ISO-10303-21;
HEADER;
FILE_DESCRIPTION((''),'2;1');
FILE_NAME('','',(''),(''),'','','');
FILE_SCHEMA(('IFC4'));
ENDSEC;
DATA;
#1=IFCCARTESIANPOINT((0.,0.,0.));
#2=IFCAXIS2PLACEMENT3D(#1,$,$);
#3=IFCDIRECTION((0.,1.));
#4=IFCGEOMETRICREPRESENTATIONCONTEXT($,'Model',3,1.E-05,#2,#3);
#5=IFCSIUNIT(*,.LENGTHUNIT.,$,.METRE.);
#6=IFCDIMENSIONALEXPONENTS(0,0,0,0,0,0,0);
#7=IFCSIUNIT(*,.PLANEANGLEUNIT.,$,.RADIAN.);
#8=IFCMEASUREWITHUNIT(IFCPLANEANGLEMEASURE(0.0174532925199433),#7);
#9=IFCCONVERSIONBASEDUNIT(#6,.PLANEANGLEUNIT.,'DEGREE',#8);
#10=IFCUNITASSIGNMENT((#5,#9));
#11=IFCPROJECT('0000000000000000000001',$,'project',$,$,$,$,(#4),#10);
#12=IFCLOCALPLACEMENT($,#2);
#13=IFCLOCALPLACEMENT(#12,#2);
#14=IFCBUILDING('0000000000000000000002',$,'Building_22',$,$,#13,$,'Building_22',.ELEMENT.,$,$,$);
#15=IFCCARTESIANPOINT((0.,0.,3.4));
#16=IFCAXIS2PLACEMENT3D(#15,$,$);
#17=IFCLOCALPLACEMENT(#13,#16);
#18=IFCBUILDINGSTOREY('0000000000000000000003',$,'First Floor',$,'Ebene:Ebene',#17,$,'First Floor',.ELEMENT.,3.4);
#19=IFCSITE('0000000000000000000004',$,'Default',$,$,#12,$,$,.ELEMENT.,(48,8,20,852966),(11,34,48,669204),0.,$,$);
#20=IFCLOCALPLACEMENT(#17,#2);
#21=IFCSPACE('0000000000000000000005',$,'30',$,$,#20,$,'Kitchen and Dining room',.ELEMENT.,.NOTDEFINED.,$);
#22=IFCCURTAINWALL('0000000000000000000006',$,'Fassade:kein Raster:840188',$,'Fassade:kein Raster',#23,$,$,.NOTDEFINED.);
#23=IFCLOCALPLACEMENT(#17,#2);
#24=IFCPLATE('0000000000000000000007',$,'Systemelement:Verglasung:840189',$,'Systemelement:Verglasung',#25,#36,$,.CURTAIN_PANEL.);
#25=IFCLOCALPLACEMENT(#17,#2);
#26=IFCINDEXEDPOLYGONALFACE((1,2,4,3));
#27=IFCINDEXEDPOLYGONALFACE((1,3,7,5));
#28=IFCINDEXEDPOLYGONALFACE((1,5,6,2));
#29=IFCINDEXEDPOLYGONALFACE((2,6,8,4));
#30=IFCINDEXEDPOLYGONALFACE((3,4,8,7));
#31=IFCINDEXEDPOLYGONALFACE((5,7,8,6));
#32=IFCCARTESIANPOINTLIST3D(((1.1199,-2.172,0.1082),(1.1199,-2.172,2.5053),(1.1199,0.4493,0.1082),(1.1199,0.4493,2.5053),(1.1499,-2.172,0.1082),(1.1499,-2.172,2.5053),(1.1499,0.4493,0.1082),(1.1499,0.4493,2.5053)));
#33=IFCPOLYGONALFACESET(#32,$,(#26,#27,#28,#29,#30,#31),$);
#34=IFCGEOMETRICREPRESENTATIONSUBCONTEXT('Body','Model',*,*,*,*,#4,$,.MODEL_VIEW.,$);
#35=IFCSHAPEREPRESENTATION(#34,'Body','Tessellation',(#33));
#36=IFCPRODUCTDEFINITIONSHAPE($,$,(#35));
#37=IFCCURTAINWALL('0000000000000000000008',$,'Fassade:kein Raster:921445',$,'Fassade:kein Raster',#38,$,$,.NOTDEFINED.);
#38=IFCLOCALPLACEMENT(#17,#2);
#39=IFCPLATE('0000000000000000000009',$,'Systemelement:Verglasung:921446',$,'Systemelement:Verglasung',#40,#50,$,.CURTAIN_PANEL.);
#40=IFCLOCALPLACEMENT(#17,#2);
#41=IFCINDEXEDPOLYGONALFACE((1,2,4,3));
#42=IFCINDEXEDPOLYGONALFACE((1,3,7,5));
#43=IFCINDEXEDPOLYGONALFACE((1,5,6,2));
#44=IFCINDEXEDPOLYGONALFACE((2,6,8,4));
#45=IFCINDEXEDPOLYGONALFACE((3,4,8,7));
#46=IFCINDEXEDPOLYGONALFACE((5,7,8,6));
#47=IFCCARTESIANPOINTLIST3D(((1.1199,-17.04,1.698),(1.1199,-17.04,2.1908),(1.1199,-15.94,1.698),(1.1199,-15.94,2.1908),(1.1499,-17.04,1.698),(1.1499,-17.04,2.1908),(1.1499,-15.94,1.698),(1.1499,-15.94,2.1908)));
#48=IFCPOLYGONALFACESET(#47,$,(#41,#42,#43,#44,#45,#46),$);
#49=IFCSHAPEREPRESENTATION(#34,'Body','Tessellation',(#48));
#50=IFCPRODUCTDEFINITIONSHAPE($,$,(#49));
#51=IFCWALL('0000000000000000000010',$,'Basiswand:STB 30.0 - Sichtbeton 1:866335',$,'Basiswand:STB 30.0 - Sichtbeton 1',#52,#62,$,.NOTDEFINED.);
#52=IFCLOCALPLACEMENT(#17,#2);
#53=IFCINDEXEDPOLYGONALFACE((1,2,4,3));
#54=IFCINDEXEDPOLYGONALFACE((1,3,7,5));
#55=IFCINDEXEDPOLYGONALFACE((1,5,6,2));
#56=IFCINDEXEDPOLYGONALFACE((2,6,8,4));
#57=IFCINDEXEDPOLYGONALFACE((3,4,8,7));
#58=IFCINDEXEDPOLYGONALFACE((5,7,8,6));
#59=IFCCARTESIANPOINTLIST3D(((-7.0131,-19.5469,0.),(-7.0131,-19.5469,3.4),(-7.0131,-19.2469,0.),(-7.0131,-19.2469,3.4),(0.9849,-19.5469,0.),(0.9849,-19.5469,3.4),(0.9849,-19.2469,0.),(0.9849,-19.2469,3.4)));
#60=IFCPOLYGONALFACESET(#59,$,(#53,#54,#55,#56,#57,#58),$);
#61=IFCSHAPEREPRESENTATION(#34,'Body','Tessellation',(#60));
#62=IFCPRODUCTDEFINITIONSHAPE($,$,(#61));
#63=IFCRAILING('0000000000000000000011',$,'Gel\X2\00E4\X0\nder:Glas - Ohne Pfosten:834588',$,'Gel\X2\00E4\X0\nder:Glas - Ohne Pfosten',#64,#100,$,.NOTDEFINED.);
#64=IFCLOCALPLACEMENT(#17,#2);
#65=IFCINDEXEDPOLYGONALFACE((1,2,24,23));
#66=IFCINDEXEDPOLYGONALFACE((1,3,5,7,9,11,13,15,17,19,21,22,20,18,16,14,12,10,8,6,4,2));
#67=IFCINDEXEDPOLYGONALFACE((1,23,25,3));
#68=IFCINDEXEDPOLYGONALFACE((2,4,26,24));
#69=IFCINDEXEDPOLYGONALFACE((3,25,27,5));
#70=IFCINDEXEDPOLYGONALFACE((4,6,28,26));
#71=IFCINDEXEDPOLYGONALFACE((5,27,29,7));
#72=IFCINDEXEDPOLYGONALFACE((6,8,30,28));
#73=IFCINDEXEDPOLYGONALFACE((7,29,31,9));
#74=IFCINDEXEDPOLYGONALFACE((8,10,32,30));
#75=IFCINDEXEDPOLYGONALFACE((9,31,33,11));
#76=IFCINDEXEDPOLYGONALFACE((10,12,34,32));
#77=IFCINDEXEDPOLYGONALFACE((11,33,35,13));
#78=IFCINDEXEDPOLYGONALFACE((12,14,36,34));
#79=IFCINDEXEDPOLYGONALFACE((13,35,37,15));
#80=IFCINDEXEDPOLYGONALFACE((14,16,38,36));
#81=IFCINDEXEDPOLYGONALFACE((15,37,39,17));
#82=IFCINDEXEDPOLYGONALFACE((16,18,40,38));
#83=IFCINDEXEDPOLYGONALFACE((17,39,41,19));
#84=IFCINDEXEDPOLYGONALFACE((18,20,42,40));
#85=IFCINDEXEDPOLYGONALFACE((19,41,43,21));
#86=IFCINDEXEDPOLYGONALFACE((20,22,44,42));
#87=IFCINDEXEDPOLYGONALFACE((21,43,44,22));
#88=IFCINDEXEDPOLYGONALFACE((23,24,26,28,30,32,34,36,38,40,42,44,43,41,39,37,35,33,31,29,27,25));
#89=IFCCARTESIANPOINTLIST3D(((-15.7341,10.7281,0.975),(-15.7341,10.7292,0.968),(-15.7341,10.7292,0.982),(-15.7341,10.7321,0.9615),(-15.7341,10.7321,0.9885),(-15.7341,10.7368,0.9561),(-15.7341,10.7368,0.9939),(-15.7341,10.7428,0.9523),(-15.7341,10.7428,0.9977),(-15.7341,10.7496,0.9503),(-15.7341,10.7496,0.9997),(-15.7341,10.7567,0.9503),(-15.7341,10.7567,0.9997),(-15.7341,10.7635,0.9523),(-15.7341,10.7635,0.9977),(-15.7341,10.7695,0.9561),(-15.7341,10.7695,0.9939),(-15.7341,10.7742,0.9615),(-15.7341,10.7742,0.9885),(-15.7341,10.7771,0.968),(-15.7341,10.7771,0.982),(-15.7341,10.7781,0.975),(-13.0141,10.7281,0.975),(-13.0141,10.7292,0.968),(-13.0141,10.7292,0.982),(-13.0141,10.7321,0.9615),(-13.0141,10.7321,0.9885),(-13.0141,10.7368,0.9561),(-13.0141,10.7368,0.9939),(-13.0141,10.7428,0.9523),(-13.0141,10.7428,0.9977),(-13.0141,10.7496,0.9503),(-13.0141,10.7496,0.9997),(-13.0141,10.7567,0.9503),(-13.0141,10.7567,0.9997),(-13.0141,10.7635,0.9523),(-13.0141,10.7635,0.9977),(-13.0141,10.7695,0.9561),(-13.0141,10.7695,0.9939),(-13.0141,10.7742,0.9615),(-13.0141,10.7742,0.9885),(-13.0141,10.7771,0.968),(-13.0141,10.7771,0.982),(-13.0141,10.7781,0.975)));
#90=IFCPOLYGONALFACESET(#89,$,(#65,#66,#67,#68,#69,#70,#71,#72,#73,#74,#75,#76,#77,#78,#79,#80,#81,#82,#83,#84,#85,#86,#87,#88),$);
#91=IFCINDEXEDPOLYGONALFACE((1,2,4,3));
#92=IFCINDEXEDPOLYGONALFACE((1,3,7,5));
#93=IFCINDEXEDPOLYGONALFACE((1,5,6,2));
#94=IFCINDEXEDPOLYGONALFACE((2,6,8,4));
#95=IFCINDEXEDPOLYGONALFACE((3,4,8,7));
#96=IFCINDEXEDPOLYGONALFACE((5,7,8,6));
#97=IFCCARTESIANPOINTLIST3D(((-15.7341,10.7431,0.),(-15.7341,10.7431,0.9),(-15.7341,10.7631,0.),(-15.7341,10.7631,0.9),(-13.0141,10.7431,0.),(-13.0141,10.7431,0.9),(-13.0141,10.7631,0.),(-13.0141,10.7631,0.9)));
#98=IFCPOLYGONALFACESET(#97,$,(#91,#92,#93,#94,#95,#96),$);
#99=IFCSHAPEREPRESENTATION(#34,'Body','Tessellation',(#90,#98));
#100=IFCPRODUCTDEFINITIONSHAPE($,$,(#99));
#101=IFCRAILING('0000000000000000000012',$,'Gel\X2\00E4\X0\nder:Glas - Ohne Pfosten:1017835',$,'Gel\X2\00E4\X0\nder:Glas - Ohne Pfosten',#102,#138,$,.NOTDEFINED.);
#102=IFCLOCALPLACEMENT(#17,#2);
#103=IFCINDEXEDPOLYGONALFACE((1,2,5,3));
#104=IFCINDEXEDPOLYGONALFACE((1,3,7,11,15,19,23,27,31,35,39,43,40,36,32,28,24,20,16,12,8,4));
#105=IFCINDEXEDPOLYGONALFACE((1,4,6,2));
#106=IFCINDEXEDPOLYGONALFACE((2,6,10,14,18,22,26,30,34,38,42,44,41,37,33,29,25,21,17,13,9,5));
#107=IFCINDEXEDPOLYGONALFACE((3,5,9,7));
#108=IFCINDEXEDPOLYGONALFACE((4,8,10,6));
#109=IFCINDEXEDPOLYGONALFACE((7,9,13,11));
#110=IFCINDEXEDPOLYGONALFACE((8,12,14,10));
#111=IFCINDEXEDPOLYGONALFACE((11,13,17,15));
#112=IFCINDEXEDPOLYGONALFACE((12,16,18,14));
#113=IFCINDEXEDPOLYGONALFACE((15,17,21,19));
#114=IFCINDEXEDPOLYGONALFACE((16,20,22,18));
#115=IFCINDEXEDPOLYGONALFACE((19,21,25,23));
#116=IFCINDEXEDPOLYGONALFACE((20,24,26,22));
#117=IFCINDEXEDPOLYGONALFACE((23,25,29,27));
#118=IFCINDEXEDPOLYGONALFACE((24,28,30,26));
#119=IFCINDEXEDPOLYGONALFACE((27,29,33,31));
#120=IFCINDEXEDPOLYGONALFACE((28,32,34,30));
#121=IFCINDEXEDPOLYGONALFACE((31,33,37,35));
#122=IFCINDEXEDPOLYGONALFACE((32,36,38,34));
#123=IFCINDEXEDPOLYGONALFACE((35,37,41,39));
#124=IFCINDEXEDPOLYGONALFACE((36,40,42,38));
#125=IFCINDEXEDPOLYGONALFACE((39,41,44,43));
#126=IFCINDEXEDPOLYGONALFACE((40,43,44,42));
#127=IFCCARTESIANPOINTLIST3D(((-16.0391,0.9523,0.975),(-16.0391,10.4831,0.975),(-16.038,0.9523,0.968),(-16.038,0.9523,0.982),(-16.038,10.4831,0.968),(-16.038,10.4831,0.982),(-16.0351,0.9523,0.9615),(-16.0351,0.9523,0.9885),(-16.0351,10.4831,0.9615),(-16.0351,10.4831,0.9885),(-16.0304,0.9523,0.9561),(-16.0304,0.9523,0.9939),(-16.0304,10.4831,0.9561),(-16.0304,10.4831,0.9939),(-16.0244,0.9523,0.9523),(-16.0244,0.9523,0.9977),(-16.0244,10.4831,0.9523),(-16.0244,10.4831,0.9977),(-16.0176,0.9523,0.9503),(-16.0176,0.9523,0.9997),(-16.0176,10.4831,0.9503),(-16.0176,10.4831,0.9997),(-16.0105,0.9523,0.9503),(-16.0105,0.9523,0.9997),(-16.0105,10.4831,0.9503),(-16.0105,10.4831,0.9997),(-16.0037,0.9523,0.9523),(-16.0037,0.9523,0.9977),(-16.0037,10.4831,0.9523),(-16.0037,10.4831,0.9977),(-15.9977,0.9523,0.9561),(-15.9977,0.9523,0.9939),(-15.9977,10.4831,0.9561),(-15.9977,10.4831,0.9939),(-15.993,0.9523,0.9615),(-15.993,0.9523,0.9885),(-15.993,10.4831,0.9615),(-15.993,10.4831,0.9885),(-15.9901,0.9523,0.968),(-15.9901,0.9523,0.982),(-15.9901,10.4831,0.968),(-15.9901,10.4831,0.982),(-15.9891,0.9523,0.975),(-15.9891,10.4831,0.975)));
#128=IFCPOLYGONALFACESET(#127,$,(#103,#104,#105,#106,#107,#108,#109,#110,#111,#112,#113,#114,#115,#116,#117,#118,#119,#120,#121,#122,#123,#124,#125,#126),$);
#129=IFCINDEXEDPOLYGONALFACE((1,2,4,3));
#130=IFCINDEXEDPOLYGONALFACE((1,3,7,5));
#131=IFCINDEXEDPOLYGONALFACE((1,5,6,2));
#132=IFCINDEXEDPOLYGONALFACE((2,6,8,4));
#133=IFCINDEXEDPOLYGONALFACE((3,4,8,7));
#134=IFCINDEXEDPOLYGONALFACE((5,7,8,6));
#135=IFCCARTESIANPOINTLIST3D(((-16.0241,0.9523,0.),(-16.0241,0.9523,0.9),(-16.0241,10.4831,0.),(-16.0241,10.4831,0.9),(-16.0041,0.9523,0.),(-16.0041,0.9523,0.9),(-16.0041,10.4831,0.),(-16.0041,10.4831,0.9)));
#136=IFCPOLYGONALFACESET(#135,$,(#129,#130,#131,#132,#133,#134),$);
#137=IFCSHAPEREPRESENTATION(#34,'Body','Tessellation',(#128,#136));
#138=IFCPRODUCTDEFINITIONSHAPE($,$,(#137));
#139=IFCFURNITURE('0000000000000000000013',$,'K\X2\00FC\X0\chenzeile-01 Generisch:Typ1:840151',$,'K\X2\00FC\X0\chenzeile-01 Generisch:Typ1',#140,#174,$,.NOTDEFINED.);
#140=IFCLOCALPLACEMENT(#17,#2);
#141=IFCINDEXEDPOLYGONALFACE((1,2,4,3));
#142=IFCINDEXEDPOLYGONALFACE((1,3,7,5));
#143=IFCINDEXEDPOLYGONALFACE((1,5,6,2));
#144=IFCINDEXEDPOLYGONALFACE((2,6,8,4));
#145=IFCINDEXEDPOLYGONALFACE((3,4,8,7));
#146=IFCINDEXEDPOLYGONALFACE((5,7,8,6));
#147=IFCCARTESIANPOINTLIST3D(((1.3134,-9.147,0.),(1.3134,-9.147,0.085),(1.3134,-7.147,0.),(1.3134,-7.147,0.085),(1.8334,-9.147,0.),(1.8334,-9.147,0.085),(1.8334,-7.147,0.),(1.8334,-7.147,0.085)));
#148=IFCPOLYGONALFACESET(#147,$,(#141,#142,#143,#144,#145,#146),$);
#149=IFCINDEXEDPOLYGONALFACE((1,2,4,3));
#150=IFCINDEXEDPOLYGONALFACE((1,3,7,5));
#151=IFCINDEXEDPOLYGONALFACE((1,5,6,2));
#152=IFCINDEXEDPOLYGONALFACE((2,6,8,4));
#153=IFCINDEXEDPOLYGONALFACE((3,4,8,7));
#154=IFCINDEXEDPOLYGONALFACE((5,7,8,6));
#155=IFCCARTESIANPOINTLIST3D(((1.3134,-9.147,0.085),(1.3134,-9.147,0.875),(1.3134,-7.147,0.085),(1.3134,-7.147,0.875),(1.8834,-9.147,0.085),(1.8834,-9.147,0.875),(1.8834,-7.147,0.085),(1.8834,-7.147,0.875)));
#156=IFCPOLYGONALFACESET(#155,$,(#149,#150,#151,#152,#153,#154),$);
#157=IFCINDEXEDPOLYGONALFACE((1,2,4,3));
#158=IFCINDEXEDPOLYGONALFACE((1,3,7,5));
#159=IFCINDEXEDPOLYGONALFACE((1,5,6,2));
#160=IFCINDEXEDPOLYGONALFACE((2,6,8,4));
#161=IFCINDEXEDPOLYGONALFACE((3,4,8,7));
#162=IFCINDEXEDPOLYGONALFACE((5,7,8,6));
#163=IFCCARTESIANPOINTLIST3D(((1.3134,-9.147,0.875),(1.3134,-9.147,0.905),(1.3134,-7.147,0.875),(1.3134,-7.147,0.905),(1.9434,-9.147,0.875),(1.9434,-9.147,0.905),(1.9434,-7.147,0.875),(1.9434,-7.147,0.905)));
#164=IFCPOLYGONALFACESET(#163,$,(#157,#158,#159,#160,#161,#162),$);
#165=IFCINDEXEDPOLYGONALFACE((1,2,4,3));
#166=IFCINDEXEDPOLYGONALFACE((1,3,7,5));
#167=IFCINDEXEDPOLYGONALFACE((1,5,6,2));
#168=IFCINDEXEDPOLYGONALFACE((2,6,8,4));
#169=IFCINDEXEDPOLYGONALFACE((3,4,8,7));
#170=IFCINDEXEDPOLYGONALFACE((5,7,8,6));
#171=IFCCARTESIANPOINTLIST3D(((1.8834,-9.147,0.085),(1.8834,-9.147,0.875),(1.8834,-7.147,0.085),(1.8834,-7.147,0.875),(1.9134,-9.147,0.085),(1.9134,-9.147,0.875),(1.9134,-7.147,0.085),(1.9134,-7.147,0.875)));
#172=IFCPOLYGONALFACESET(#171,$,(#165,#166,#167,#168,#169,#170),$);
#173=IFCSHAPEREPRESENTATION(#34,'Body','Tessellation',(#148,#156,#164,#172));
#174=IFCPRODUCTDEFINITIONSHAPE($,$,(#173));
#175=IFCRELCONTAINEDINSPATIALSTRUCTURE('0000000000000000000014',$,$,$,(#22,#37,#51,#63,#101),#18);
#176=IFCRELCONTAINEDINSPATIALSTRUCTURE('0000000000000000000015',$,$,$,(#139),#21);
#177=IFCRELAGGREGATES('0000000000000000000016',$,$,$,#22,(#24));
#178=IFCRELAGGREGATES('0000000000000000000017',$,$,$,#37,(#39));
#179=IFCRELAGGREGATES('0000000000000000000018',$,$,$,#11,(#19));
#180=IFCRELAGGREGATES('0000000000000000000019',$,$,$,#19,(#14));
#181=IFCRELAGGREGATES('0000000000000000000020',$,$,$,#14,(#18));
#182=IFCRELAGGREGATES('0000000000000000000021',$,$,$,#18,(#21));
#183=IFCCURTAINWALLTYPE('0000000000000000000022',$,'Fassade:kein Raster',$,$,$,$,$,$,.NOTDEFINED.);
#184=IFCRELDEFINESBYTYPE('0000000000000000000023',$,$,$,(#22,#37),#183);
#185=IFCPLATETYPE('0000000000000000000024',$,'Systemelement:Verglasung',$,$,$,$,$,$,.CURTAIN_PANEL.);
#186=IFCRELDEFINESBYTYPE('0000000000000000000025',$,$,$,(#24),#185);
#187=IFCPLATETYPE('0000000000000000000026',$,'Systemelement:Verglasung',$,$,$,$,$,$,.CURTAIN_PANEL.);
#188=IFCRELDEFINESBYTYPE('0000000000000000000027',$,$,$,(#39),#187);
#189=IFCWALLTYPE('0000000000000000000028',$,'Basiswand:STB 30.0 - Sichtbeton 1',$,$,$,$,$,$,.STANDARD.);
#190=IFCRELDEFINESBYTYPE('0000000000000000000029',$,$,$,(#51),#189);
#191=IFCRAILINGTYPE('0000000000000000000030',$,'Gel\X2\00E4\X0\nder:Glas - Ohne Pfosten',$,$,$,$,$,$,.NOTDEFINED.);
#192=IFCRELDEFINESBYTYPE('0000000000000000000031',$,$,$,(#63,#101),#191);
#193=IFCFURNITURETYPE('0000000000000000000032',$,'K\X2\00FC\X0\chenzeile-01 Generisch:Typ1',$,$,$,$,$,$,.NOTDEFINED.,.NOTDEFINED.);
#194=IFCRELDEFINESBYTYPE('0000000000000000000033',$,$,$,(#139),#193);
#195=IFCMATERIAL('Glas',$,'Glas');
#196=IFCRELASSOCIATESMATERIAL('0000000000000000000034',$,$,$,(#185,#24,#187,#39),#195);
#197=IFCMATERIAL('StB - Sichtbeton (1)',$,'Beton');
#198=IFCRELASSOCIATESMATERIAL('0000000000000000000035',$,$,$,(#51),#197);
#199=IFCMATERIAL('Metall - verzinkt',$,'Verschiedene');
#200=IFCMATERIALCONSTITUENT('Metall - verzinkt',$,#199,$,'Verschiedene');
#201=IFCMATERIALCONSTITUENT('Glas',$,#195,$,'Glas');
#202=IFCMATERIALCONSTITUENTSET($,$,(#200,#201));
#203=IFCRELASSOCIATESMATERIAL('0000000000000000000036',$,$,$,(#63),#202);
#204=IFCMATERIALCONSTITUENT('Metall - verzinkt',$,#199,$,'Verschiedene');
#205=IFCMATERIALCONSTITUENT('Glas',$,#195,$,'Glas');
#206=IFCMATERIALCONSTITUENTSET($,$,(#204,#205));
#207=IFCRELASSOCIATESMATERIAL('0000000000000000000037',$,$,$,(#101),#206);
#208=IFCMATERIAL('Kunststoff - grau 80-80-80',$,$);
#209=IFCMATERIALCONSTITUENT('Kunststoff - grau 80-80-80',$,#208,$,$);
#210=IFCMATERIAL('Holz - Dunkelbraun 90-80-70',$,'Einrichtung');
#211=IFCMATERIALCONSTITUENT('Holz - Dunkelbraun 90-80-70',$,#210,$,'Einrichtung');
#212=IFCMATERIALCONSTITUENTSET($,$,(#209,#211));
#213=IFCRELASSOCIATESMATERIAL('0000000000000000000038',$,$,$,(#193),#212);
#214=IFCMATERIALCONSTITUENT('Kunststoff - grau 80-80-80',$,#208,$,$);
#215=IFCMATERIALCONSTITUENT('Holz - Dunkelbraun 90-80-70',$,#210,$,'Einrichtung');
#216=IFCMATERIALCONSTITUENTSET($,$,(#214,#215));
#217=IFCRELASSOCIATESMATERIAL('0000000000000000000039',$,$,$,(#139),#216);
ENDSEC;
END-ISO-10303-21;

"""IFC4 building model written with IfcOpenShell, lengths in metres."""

from ifc_helpers import new_model, entity, si_unit, converted_unit, direction, frame, origin, place, context, subcontext, project, spatial, arc, indexed_curve, outline, extrude, source, transform, mapped, material, constituent, constituent_set, type_object, type_shapes, element, aggregate, save


model = new_model("IFC4")

# Units and contexts
model_context = context("Model", 3, precision=1e-05, world=origin(), true_north=direction((0.0, 1.0)))
body_context = subcontext(model_context, "Body", "Model", "MODEL_VIEW")
ifc_project = project(units=[si_unit("LENGTHUNIT", "METRE"), converted_unit("PLANEANGLEUNIT", "DEGREE", entity("IfcPlaneAngleMeasure", 0.0174532925199433), si_unit("PLANEANGLEUNIT", "RADIAN"), dimensions=[0, 0, 0, 0, 0, 0, 0])], contexts=[model_context])

# Site, building, storey
site_placement = place(None, origin())
site = spatial("IfcSite", under=ifc_project, at=site_placement, Name="Default", CompositionType="ELEMENT", RefLatitude=(48, 8, 20, 852966), RefLongitude=(11, 34, 48, 669204), RefElevation=0.0)
building_placement = place(site_placement, origin())
building = spatial("IfcBuilding", under=site, at=building_placement, Name="Building_22", LongName="Building_22", CompositionType="ELEMENT")
storey_placement = place(building_placement, frame((0.0, 0.0, 3.4)))
storey = spatial("IfcBuildingStorey", under=building, at=storey_placement, Name="First Floor", ObjectType="Ebene:Ebene", LongName="First Floor", CompositionType="ELEMENT", Elevation=3.4)

# Curtain walls, plates
curtain_wall_type = type_object("IfcCurtainWallType", Name="Fassade:kein Raster", PredefinedType="NOTDEFINED")
ifc_material_1 = material(Name="Glas", Category="Glas")
curtain_wall_1_placement = place(storey_placement, frame((0.0, 0.0, -3.4)))
curtain_wall_1 = element("IfcCurtainWall", 1, at=curtain_wall_1_placement, inside=storey, type_object=curtain_wall_type, Name="Fassade:kein Raster:840188", ObjectType="Fassade:kein Raster", PredefinedType="NOTDEFINED")
plate_type_1 = type_object("IfcPlateType", Name="Systemelement:Verglasung", PredefinedType="CURTAIN_PANEL", material=ifc_material_1)
shared_shape_1 = source(origin(), body_context, "Body", "SweptSolid", [
    extrude(outline(indexed_curve([(-0.015, -1.3107), (0.015, -1.3107), (0.015, 1.3107), (-0.015, 1.3107), (-0.015, -1.3107)], self_intersect=False)), frame((0.0, 0.0, 0.0), z_axis=(0.0, 0.0, 1.0), x_axis=(0.0, 1.0, 0.0)), (0.0, 0.0, 1.0), 2.3972),
])
type_shapes(plate_type_1, [shared_shape_1])
plate_1_placement = place(curtain_wall_1_placement, frame((1.1349, -0.8614, 3.5082), z_axis=(0.0, 0.0, 1.0), x_axis=(0.0, -1.0, 0.0)))
plate_1 = element("IfcPlate", 2, at=plate_1_placement, type_object=plate_type_1, material=ifc_material_1, Name="Systemelement:Verglasung:840189", ObjectType="Systemelement:Verglasung", PredefinedType="CURTAIN_PANEL", context=body_context, shape_type="MappedRepresentation", body=[
    mapped(shared_shape_1, transform((0.0, 0.0, 0.0), scale=1.0)),
])
aggregate(curtain_wall_1, [plate_1])
curtain_wall_2_placement = place(storey_placement, frame((0.0, 0.0, -3.4)))
curtain_wall_2 = element("IfcCurtainWall", 3, at=curtain_wall_2_placement, inside=storey, type_object=curtain_wall_type, Name="Fassade:kein Raster:921445", ObjectType="Fassade:kein Raster", PredefinedType="NOTDEFINED")
plate_type_2 = type_object("IfcPlateType", Name="Systemelement:Verglasung", PredefinedType="CURTAIN_PANEL", material=ifc_material_1)
shared_shape_2 = source(origin(), body_context, "Body", "SweptSolid", [
    extrude(outline(indexed_curve([(-0.015, -0.55), (0.015, -0.55), (0.015, 0.55), (-0.015, 0.55), (-0.015, -0.55)], self_intersect=False)), frame((0.0, 0.0, 0.0), z_axis=(0.0, 0.0, 1.0), x_axis=(0.0, 1.0, 0.0)), (0.0, 0.0, 1.0), 0.4929),
])
type_shapes(plate_type_2, [shared_shape_2])
plate_2_placement = place(curtain_wall_2_placement, frame((1.1349, -16.49, 5.098), z_axis=(0.0, 0.0, 1.0), x_axis=(0.0, -1.0, 0.0)))
plate_2 = element("IfcPlate", 4, at=plate_2_placement, type_object=plate_type_2, material=ifc_material_1, Name="Systemelement:Verglasung:921446", ObjectType="Systemelement:Verglasung", PredefinedType="CURTAIN_PANEL", context=body_context, shape_type="MappedRepresentation", body=[
    mapped(shared_shape_2, transform((0.0, 0.0, 0.0), scale=1.0)),
])
aggregate(curtain_wall_2, [plate_2])

# Wall
ifc_material_2 = material(Name="StB - Sichtbeton (1)", Category="Beton")
wall_type = type_object("IfcWallType", Name="Basiswand:STB 30.0 - Sichtbeton 1", PredefinedType="STANDARD")
wall_placement = place(storey_placement, frame((-7.0131, -19.3969, 0.0)))
element("IfcWall", 5, at=wall_placement, inside=storey, type_object=wall_type, material=ifc_material_2, Name="Basiswand:STB 30.0 - Sichtbeton 1:866335", ObjectType="Basiswand:STB 30.0 - Sichtbeton 1", PredefinedType="NOTDEFINED", context=body_context, shape_type="SweptSolid", body=[
    extrude(outline(indexed_curve([(7.998, 0.15), (0.0, 0.15), (0.0, -0.15), (7.998, -0.15), (7.998, 0.15)], self_intersect=False)), origin(), (0.0, 0.0, 1.0), 3.4),
])

# Railings
ifc_material_3 = material(Name="Metall - verzinkt", Category="Verschiedene")
ifc_constituent_1 = constituent(ifc_material_3, Name="Metall - verzinkt", Category="Verschiedene")
ifc_constituent_2 = constituent(ifc_material_1, Name="Glas", Category="Glas")
ifc_constituent_set_1 = constituent_set(constituents=[ifc_constituent_1, ifc_constituent_2])
railing_type = type_object("IfcRailingType", Name="Geländer:Glas - Ohne Pfosten", PredefinedType="NOTDEFINED")
railing_1_placement = place(storey_placement, origin())
element("IfcRailing", 6, at=railing_1_placement, inside=storey, type_object=railing_type, material=ifc_constituent_set_1, Name="Geländer:Glas - Ohne Pfosten:834588", ObjectType="Geländer:Glas - Ohne Pfosten", PredefinedType="NOTDEFINED", context=body_context, shape_type="SweptSolid", body=[
    extrude(outline(indexed_curve([(-0.025, 0.0), (0.0, -0.025), (0.025, 0.0), (0.0, 0.025)], segments=[arc(1, 2, 3), arc(3, 4, 1)], self_intersect=False)), frame((-15.7341, 10.7531, 0.975), z_axis=(1.0, 0.0, 0.0), x_axis=(0.0, 1.0, 0.0)), (0.0, 0.0, 1.0), 2.72),
    extrude(outline(indexed_curve([(-1.36, -0.01), (1.36, -0.01), (1.36, 0.01), (-1.36, 0.01), (-1.36, -0.01)], self_intersect=False)), frame((-14.3741, 10.7531, 0.0), z_axis=(0.0, 0.0, 1.0), x_axis=(-1.0, 0.0, 0.0)), (0.0, 0.0, 1.0), 0.9),
])
ifc_constituent_3 = constituent(ifc_material_3, Name="Metall - verzinkt", Category="Verschiedene")
ifc_constituent_4 = constituent(ifc_material_1, Name="Glas", Category="Glas")
ifc_constituent_set_2 = constituent_set(constituents=[ifc_constituent_3, ifc_constituent_4])
railing_2_placement = place(storey_placement, origin())
element("IfcRailing", 7, at=railing_2_placement, inside=storey, type_object=railing_type, material=ifc_constituent_set_2, Name="Geländer:Glas - Ohne Pfosten:1017835", ObjectType="Geländer:Glas - Ohne Pfosten", PredefinedType="NOTDEFINED", context=body_context, shape_type="SweptSolid", body=[
    extrude(outline(indexed_curve([(-0.025, 0.0), (0.0, -0.025), (0.025, 0.0), (0.0, 0.025)], segments=[arc(1, 2, 3), arc(3, 4, 1)], self_intersect=False)), frame((-16.0141, 0.9523, 0.975), z_axis=(0.0, 1.0, 0.0), x_axis=(-1.0, 0.0, 0.0)), (0.0, 0.0, 1.0), 9.5309),
    extrude(outline(indexed_curve([(-4.7654, -0.01), (4.7654, -0.01), (4.7654, 0.01), (-4.7654, 0.01), (-4.7654, -0.01)], self_intersect=False)), frame((-16.0141, 5.7177, 0.0), z_axis=(0.0, 0.0, 1.0), x_axis=(0.0, -1.0, 0.0)), (0.0, 0.0, 1.0), 0.9),
])

# Shared definitions
space_1_placement = place(storey_placement, origin())
space_1 = spatial("IfcSpace", under=storey, at=space_1_placement, Name="30", LongName="Kitchen and Dining room", CompositionType="ELEMENT", PredefinedType="NOTDEFINED")

# Furniture
ifc_material_4 = material(Name="Kunststoff - grau 80-80-80")
ifc_constituent_5 = constituent(ifc_material_4, Name="Kunststoff - grau 80-80-80")
ifc_material_5 = material(Name="Holz - Dunkelbraun 90-80-70", Category="Einrichtung")
ifc_constituent_6 = constituent(ifc_material_5, Name="Holz - Dunkelbraun 90-80-70", Category="Einrichtung")
ifc_constituent_set_3 = constituent_set(constituents=[ifc_constituent_5, ifc_constituent_6])
ifc_constituent_7 = constituent(ifc_material_4, Name="Kunststoff - grau 80-80-80")
ifc_constituent_8 = constituent(ifc_material_5, Name="Holz - Dunkelbraun 90-80-70", Category="Einrichtung")
ifc_constituent_set_4 = constituent_set(constituents=[ifc_constituent_7, ifc_constituent_8])
furniture_type_1 = type_object("IfcFurnitureType", Name="Küchenzeile-01 Generisch:Typ1", AssemblyPlace="NOTDEFINED", PredefinedType="NOTDEFINED", material=ifc_constituent_set_4)
shared_shape_3 = source(origin(), body_context, "Body", "SweptSolid", [
    extrude(outline(indexed_curve([(-1.0, -0.26), (1.0, -0.26), (1.0, 0.26), (-1.0, 0.26), (-1.0, -0.26)], self_intersect=False)), frame((-0.72, 0.04, 0.0)), (0.0, 0.0, 1.0), 0.085),
    extrude(outline(indexed_curve([(-1.0, -0.285), (1.0, -0.285), (1.0, 0.285), (-1.0, 0.285), (-1.0, -0.285)], self_intersect=False)), frame((-0.72, 0.015, 0.085)), (0.0, 0.0, 1.0), 0.79),
    extrude(outline(indexed_curve([(-1.0, -0.315), (1.0, -0.315), (1.0, 0.315), (-1.0, 0.315), (-1.0, -0.315)], self_intersect=False)), frame((-0.72, -0.015, 0.875)), (0.0, 0.0, 1.0), 0.03),
    extrude(outline(indexed_curve([(-1.0, -0.015), (1.0, -0.015), (1.0, 0.015), (-1.0, 0.015), (-1.0, -0.015)], self_intersect=False)), frame((-0.72, -0.285, 0.085)), (0.0, 0.0, 1.0), 0.79),
])
type_shapes(furniture_type_1, [shared_shape_3])
furniture_1_placement = place(space_1_placement, frame((1.6134, -7.427, 0.0), z_axis=(0.0, 0.0, 1.0), x_axis=(0.0, 1.0, 0.0)))
element("IfcFurniture", 8, at=furniture_1_placement, inside=space_1, type_object=furniture_type_1, material=ifc_constituent_set_3, Name="Küchenzeile-01 Generisch:Typ1:840151", ObjectType="Küchenzeile-01 Generisch:Typ1", PredefinedType="NOTDEFINED", context=body_context, shape_type="MappedRepresentation", body=[
    mapped(shared_shape_3, transform((0.0, 0.0, 0.0), scale=1.0)),
])

save(model, "model.ifc")
